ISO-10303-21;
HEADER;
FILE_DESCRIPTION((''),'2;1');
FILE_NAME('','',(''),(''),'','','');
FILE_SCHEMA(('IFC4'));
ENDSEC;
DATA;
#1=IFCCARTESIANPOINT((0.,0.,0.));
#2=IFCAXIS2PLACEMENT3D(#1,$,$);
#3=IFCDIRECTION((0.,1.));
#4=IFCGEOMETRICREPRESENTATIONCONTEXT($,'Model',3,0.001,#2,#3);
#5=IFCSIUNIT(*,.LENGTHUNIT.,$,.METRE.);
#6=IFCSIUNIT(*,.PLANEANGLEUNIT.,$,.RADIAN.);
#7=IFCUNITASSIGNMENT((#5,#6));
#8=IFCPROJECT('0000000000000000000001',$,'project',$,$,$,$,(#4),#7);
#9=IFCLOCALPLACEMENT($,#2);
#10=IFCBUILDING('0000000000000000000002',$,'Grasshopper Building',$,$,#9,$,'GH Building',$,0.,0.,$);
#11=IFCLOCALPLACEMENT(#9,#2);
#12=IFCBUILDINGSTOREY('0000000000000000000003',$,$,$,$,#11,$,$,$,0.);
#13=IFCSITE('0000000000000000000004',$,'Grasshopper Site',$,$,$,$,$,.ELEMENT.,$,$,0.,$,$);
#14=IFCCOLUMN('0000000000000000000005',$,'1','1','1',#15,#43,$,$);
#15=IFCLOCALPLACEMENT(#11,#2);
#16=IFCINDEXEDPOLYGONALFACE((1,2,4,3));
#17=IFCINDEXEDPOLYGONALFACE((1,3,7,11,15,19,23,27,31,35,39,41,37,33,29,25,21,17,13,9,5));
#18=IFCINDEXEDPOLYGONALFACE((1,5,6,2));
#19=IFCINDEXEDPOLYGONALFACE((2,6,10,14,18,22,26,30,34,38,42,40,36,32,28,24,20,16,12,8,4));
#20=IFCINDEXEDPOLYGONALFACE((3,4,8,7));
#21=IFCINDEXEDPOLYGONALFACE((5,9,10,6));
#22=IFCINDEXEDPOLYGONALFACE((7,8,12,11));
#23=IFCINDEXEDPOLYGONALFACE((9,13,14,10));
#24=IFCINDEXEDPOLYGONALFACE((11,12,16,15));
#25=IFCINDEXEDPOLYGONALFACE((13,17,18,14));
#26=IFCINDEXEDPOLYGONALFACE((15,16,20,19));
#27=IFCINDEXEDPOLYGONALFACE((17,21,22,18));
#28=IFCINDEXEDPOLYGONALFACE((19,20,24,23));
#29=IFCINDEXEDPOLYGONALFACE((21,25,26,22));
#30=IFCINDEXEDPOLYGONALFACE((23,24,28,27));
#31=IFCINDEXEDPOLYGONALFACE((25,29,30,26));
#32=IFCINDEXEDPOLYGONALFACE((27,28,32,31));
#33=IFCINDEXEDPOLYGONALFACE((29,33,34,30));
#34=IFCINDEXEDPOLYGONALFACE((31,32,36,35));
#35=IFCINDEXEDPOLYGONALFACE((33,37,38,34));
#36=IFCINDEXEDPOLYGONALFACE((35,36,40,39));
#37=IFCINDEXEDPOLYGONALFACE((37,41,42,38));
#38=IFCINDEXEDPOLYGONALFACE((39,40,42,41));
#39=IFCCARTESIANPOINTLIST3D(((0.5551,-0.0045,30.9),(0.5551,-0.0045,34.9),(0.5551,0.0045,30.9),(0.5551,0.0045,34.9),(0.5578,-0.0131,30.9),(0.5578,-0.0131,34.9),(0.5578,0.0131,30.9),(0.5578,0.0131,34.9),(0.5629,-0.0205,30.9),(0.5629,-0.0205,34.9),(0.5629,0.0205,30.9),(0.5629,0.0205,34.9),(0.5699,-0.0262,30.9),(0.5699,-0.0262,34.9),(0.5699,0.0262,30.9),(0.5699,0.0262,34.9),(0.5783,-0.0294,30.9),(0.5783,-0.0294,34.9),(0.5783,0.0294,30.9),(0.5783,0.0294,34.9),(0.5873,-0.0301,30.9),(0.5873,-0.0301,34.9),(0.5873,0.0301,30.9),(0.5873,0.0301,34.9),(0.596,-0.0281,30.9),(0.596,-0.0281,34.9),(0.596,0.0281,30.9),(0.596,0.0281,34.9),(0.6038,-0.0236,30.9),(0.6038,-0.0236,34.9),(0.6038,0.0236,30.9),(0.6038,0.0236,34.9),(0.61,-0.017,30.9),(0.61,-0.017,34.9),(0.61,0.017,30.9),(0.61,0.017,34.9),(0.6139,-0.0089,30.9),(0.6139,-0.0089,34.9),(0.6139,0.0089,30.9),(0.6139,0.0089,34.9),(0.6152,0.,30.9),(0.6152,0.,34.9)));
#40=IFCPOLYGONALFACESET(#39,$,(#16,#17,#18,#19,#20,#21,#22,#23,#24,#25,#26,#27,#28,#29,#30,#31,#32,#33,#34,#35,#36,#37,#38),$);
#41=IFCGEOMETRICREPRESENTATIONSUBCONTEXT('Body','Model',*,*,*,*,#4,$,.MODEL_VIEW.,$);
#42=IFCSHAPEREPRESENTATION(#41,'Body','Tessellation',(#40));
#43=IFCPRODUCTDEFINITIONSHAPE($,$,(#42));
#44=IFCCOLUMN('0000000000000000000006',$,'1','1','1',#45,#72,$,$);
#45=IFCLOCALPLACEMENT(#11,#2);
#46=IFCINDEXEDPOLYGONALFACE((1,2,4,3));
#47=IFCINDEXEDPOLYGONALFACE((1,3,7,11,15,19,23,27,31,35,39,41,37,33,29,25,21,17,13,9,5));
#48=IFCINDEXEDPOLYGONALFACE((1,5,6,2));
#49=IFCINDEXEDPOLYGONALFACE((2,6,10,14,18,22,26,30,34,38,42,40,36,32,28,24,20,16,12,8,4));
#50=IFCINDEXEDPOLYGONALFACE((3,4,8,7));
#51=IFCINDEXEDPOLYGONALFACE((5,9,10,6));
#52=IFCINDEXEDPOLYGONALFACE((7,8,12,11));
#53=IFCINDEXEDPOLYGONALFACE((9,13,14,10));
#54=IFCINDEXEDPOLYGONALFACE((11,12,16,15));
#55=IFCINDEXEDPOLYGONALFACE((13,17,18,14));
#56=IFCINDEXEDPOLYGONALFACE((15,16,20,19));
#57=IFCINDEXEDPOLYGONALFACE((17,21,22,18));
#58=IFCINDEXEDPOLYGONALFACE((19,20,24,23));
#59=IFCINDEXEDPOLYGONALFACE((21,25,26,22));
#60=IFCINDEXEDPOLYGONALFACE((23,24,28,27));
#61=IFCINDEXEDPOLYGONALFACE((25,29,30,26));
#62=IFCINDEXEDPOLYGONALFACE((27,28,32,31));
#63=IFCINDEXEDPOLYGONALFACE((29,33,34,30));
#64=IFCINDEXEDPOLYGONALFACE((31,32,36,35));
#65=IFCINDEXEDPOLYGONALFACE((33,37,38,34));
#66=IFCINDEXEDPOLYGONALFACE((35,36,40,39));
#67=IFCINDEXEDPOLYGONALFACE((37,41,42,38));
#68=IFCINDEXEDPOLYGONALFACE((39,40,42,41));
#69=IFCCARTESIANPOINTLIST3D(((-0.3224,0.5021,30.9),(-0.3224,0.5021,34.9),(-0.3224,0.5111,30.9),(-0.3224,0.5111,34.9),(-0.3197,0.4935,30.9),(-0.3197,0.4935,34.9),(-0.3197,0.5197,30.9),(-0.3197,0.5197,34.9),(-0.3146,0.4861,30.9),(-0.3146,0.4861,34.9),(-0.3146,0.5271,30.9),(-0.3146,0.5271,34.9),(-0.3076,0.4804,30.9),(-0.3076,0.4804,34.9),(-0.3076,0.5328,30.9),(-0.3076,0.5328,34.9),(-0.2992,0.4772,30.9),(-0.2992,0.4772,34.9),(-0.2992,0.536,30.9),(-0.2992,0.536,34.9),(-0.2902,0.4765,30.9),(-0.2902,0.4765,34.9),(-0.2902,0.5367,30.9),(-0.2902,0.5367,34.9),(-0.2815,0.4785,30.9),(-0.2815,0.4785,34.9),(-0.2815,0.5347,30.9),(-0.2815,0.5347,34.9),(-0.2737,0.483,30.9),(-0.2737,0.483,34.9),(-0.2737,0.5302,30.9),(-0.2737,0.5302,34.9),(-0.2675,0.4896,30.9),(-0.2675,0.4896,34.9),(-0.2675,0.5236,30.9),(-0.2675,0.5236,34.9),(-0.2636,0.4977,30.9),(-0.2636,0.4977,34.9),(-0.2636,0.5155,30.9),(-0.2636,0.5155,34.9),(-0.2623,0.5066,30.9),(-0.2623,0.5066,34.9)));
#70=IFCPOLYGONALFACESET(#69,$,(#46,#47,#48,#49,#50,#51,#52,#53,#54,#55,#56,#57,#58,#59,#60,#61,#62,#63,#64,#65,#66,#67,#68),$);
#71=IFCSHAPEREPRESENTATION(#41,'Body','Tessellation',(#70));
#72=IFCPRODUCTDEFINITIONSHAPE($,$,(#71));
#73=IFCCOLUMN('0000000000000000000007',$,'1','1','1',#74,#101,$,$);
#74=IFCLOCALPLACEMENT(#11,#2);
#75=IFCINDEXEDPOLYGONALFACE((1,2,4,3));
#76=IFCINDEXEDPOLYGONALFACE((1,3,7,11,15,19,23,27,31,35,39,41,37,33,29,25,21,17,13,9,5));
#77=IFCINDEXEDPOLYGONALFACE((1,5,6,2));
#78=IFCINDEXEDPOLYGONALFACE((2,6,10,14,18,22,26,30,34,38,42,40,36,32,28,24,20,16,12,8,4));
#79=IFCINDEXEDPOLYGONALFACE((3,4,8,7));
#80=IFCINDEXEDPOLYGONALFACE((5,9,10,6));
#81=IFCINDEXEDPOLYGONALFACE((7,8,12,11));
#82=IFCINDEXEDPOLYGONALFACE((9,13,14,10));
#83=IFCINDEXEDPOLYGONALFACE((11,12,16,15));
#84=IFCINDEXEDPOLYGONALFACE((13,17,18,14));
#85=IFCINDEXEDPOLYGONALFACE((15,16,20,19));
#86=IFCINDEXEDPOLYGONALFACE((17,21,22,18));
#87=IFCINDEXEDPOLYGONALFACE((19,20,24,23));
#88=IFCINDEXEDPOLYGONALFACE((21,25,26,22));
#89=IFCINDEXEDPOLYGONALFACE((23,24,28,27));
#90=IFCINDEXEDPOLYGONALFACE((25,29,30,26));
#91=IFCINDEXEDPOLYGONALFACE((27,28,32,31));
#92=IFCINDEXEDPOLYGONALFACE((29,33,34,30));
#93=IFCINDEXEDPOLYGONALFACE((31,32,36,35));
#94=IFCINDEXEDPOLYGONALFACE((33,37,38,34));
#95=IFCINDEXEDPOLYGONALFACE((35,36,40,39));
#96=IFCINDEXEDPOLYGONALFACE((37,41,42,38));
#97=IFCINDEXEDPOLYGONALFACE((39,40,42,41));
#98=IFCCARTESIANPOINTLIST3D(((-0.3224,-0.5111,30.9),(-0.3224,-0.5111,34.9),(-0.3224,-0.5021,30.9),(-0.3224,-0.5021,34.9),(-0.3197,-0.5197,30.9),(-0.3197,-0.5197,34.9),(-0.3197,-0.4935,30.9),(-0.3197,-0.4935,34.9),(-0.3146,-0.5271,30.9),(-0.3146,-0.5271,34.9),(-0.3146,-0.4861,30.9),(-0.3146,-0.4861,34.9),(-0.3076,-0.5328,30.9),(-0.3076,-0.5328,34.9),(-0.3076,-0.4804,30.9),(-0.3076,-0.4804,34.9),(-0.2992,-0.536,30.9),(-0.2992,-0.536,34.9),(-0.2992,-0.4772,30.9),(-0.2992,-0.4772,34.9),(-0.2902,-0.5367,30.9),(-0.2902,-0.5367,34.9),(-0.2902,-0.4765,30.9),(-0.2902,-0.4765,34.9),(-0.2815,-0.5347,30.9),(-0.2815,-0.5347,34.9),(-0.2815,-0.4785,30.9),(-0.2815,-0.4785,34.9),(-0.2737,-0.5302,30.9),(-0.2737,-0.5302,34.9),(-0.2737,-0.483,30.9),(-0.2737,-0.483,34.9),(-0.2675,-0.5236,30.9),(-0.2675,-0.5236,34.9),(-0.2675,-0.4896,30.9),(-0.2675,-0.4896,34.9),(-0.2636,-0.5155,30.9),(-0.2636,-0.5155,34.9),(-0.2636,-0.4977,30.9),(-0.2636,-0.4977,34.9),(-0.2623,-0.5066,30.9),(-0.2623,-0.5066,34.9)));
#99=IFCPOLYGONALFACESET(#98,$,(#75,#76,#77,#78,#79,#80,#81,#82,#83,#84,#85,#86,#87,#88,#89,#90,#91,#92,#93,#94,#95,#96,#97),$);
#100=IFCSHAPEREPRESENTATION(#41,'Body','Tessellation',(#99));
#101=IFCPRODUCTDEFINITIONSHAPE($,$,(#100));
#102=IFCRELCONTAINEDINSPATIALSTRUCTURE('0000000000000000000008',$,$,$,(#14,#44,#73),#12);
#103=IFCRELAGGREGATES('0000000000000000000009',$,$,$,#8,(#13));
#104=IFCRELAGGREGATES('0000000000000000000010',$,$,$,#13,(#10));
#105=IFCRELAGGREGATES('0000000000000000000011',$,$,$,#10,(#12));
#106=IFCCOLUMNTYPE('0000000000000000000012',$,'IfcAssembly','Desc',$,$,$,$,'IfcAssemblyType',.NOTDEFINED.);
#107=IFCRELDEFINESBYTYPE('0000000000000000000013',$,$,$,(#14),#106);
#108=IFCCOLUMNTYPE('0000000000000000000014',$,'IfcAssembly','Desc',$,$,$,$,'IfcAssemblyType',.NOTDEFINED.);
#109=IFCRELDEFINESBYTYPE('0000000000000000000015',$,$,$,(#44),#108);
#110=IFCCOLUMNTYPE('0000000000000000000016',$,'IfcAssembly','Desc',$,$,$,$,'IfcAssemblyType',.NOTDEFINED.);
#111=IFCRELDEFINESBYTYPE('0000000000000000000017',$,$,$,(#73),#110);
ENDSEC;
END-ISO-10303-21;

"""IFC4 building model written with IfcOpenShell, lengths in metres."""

from ifc_helpers import new_model, si_unit, direction, frame, origin, place, context, subcontext, project, spatial, circle, extrude, source, transform, mapped, type_object, type_shapes, element, save


model = new_model("IFC4")

# Units and contexts
model_context = context("Model", 3, precision=0.001, world=origin(), true_north=direction((0.0, 1.0)))
body_context = subcontext(model_context, "Body", "Model", "MODEL_VIEW")
ifc_project = project(units=[si_unit("LENGTHUNIT", "METRE"), si_unit("PLANEANGLEUNIT", "RADIAN")], contexts=[model_context])

# Site, building, storey
site = spatial("IfcSite", under=ifc_project, Name="Grasshopper Site", CompositionType="ELEMENT", RefElevation=0.0)
building_placement = place(None, origin())
building = spatial("IfcBuilding", under=site, at=building_placement, Name="Grasshopper Building", LongName="GH Building", ElevationOfRefHeight=0.0, ElevationOfTerrain=0.0)
storey_placement = place(building_placement, origin())
storey = spatial("IfcBuildingStorey", under=building, at=storey_placement, Elevation=0.0)

# Columns
column_type_1 = type_object("IfcColumnType", Name="IfcAssembly", Description="Desc", ElementType="IfcAssemblyType", PredefinedType="NOTDEFINED")
shared_shape_1 = source(origin(), body_context, "Body", "SweptSolid", [
    extrude(circle(Radius=0.0302), frame((0.585, 0.0, 34.9), z_axis=(0.0, 0.0, -1.0), x_axis=(1.0, 0.0, 0.0)), (0.0, 0.0, 1.0), 4.0),
])
type_shapes(column_type_1, [shared_shape_1])
column_1_placement = place(storey_placement, origin())
element("IfcColumn", 1, at=column_1_placement, inside=storey, type_object=column_type_1, Name="1", Description="1", ObjectType="1", context=body_context, shape_type="MappedRepresentation", body=[
    mapped(shared_shape_1, transform((0.0, 0.0, 0.0), scale=1.0)),
])
column_type_2 = type_object("IfcColumnType", Name="IfcAssembly", Description="Desc", ElementType="IfcAssemblyType", PredefinedType="NOTDEFINED")
shared_shape_2 = source(origin(), body_context, "Body", "SweptSolid", [
    extrude(circle(Radius=0.0302), frame((-0.2925, 0.5066, 34.9), z_axis=(0.0, 0.0, -1.0), x_axis=(1.0, 0.0, 0.0)), (0.0, 0.0, 1.0), 4.0),
])
type_shapes(column_type_2, [shared_shape_2])
column_2_placement = place(storey_placement, origin())
element("IfcColumn", 2, at=column_2_placement, inside=storey, type_object=column_type_2, Name="1", Description="1", ObjectType="1", context=body_context, shape_type="MappedRepresentation", body=[
    mapped(shared_shape_2, transform((0.0, 0.0, 0.0), scale=1.0)),
])
column_type_3 = type_object("IfcColumnType", Name="IfcAssembly", Description="Desc", ElementType="IfcAssemblyType", PredefinedType="NOTDEFINED")
shared_shape_3 = source(origin(), body_context, "Body", "SweptSolid", [
    extrude(circle(Radius=0.0302), frame((-0.2925, -0.5066, 34.9), z_axis=(0.0, 0.0, -1.0), x_axis=(1.0, 0.0, 0.0)), (0.0, 0.0, 1.0), 4.0),
])
type_shapes(column_type_3, [shared_shape_3])
column_3_placement = place(storey_placement, origin())
element("IfcColumn", 3, at=column_3_placement, inside=storey, type_object=column_type_3, Name="1", Description="1", ObjectType="1", context=body_context, shape_type="MappedRepresentation", body=[
    mapped(shared_shape_3, transform((0.0, 0.0, 0.0), scale=1.0)),
])

save(model, "model.ifc")
